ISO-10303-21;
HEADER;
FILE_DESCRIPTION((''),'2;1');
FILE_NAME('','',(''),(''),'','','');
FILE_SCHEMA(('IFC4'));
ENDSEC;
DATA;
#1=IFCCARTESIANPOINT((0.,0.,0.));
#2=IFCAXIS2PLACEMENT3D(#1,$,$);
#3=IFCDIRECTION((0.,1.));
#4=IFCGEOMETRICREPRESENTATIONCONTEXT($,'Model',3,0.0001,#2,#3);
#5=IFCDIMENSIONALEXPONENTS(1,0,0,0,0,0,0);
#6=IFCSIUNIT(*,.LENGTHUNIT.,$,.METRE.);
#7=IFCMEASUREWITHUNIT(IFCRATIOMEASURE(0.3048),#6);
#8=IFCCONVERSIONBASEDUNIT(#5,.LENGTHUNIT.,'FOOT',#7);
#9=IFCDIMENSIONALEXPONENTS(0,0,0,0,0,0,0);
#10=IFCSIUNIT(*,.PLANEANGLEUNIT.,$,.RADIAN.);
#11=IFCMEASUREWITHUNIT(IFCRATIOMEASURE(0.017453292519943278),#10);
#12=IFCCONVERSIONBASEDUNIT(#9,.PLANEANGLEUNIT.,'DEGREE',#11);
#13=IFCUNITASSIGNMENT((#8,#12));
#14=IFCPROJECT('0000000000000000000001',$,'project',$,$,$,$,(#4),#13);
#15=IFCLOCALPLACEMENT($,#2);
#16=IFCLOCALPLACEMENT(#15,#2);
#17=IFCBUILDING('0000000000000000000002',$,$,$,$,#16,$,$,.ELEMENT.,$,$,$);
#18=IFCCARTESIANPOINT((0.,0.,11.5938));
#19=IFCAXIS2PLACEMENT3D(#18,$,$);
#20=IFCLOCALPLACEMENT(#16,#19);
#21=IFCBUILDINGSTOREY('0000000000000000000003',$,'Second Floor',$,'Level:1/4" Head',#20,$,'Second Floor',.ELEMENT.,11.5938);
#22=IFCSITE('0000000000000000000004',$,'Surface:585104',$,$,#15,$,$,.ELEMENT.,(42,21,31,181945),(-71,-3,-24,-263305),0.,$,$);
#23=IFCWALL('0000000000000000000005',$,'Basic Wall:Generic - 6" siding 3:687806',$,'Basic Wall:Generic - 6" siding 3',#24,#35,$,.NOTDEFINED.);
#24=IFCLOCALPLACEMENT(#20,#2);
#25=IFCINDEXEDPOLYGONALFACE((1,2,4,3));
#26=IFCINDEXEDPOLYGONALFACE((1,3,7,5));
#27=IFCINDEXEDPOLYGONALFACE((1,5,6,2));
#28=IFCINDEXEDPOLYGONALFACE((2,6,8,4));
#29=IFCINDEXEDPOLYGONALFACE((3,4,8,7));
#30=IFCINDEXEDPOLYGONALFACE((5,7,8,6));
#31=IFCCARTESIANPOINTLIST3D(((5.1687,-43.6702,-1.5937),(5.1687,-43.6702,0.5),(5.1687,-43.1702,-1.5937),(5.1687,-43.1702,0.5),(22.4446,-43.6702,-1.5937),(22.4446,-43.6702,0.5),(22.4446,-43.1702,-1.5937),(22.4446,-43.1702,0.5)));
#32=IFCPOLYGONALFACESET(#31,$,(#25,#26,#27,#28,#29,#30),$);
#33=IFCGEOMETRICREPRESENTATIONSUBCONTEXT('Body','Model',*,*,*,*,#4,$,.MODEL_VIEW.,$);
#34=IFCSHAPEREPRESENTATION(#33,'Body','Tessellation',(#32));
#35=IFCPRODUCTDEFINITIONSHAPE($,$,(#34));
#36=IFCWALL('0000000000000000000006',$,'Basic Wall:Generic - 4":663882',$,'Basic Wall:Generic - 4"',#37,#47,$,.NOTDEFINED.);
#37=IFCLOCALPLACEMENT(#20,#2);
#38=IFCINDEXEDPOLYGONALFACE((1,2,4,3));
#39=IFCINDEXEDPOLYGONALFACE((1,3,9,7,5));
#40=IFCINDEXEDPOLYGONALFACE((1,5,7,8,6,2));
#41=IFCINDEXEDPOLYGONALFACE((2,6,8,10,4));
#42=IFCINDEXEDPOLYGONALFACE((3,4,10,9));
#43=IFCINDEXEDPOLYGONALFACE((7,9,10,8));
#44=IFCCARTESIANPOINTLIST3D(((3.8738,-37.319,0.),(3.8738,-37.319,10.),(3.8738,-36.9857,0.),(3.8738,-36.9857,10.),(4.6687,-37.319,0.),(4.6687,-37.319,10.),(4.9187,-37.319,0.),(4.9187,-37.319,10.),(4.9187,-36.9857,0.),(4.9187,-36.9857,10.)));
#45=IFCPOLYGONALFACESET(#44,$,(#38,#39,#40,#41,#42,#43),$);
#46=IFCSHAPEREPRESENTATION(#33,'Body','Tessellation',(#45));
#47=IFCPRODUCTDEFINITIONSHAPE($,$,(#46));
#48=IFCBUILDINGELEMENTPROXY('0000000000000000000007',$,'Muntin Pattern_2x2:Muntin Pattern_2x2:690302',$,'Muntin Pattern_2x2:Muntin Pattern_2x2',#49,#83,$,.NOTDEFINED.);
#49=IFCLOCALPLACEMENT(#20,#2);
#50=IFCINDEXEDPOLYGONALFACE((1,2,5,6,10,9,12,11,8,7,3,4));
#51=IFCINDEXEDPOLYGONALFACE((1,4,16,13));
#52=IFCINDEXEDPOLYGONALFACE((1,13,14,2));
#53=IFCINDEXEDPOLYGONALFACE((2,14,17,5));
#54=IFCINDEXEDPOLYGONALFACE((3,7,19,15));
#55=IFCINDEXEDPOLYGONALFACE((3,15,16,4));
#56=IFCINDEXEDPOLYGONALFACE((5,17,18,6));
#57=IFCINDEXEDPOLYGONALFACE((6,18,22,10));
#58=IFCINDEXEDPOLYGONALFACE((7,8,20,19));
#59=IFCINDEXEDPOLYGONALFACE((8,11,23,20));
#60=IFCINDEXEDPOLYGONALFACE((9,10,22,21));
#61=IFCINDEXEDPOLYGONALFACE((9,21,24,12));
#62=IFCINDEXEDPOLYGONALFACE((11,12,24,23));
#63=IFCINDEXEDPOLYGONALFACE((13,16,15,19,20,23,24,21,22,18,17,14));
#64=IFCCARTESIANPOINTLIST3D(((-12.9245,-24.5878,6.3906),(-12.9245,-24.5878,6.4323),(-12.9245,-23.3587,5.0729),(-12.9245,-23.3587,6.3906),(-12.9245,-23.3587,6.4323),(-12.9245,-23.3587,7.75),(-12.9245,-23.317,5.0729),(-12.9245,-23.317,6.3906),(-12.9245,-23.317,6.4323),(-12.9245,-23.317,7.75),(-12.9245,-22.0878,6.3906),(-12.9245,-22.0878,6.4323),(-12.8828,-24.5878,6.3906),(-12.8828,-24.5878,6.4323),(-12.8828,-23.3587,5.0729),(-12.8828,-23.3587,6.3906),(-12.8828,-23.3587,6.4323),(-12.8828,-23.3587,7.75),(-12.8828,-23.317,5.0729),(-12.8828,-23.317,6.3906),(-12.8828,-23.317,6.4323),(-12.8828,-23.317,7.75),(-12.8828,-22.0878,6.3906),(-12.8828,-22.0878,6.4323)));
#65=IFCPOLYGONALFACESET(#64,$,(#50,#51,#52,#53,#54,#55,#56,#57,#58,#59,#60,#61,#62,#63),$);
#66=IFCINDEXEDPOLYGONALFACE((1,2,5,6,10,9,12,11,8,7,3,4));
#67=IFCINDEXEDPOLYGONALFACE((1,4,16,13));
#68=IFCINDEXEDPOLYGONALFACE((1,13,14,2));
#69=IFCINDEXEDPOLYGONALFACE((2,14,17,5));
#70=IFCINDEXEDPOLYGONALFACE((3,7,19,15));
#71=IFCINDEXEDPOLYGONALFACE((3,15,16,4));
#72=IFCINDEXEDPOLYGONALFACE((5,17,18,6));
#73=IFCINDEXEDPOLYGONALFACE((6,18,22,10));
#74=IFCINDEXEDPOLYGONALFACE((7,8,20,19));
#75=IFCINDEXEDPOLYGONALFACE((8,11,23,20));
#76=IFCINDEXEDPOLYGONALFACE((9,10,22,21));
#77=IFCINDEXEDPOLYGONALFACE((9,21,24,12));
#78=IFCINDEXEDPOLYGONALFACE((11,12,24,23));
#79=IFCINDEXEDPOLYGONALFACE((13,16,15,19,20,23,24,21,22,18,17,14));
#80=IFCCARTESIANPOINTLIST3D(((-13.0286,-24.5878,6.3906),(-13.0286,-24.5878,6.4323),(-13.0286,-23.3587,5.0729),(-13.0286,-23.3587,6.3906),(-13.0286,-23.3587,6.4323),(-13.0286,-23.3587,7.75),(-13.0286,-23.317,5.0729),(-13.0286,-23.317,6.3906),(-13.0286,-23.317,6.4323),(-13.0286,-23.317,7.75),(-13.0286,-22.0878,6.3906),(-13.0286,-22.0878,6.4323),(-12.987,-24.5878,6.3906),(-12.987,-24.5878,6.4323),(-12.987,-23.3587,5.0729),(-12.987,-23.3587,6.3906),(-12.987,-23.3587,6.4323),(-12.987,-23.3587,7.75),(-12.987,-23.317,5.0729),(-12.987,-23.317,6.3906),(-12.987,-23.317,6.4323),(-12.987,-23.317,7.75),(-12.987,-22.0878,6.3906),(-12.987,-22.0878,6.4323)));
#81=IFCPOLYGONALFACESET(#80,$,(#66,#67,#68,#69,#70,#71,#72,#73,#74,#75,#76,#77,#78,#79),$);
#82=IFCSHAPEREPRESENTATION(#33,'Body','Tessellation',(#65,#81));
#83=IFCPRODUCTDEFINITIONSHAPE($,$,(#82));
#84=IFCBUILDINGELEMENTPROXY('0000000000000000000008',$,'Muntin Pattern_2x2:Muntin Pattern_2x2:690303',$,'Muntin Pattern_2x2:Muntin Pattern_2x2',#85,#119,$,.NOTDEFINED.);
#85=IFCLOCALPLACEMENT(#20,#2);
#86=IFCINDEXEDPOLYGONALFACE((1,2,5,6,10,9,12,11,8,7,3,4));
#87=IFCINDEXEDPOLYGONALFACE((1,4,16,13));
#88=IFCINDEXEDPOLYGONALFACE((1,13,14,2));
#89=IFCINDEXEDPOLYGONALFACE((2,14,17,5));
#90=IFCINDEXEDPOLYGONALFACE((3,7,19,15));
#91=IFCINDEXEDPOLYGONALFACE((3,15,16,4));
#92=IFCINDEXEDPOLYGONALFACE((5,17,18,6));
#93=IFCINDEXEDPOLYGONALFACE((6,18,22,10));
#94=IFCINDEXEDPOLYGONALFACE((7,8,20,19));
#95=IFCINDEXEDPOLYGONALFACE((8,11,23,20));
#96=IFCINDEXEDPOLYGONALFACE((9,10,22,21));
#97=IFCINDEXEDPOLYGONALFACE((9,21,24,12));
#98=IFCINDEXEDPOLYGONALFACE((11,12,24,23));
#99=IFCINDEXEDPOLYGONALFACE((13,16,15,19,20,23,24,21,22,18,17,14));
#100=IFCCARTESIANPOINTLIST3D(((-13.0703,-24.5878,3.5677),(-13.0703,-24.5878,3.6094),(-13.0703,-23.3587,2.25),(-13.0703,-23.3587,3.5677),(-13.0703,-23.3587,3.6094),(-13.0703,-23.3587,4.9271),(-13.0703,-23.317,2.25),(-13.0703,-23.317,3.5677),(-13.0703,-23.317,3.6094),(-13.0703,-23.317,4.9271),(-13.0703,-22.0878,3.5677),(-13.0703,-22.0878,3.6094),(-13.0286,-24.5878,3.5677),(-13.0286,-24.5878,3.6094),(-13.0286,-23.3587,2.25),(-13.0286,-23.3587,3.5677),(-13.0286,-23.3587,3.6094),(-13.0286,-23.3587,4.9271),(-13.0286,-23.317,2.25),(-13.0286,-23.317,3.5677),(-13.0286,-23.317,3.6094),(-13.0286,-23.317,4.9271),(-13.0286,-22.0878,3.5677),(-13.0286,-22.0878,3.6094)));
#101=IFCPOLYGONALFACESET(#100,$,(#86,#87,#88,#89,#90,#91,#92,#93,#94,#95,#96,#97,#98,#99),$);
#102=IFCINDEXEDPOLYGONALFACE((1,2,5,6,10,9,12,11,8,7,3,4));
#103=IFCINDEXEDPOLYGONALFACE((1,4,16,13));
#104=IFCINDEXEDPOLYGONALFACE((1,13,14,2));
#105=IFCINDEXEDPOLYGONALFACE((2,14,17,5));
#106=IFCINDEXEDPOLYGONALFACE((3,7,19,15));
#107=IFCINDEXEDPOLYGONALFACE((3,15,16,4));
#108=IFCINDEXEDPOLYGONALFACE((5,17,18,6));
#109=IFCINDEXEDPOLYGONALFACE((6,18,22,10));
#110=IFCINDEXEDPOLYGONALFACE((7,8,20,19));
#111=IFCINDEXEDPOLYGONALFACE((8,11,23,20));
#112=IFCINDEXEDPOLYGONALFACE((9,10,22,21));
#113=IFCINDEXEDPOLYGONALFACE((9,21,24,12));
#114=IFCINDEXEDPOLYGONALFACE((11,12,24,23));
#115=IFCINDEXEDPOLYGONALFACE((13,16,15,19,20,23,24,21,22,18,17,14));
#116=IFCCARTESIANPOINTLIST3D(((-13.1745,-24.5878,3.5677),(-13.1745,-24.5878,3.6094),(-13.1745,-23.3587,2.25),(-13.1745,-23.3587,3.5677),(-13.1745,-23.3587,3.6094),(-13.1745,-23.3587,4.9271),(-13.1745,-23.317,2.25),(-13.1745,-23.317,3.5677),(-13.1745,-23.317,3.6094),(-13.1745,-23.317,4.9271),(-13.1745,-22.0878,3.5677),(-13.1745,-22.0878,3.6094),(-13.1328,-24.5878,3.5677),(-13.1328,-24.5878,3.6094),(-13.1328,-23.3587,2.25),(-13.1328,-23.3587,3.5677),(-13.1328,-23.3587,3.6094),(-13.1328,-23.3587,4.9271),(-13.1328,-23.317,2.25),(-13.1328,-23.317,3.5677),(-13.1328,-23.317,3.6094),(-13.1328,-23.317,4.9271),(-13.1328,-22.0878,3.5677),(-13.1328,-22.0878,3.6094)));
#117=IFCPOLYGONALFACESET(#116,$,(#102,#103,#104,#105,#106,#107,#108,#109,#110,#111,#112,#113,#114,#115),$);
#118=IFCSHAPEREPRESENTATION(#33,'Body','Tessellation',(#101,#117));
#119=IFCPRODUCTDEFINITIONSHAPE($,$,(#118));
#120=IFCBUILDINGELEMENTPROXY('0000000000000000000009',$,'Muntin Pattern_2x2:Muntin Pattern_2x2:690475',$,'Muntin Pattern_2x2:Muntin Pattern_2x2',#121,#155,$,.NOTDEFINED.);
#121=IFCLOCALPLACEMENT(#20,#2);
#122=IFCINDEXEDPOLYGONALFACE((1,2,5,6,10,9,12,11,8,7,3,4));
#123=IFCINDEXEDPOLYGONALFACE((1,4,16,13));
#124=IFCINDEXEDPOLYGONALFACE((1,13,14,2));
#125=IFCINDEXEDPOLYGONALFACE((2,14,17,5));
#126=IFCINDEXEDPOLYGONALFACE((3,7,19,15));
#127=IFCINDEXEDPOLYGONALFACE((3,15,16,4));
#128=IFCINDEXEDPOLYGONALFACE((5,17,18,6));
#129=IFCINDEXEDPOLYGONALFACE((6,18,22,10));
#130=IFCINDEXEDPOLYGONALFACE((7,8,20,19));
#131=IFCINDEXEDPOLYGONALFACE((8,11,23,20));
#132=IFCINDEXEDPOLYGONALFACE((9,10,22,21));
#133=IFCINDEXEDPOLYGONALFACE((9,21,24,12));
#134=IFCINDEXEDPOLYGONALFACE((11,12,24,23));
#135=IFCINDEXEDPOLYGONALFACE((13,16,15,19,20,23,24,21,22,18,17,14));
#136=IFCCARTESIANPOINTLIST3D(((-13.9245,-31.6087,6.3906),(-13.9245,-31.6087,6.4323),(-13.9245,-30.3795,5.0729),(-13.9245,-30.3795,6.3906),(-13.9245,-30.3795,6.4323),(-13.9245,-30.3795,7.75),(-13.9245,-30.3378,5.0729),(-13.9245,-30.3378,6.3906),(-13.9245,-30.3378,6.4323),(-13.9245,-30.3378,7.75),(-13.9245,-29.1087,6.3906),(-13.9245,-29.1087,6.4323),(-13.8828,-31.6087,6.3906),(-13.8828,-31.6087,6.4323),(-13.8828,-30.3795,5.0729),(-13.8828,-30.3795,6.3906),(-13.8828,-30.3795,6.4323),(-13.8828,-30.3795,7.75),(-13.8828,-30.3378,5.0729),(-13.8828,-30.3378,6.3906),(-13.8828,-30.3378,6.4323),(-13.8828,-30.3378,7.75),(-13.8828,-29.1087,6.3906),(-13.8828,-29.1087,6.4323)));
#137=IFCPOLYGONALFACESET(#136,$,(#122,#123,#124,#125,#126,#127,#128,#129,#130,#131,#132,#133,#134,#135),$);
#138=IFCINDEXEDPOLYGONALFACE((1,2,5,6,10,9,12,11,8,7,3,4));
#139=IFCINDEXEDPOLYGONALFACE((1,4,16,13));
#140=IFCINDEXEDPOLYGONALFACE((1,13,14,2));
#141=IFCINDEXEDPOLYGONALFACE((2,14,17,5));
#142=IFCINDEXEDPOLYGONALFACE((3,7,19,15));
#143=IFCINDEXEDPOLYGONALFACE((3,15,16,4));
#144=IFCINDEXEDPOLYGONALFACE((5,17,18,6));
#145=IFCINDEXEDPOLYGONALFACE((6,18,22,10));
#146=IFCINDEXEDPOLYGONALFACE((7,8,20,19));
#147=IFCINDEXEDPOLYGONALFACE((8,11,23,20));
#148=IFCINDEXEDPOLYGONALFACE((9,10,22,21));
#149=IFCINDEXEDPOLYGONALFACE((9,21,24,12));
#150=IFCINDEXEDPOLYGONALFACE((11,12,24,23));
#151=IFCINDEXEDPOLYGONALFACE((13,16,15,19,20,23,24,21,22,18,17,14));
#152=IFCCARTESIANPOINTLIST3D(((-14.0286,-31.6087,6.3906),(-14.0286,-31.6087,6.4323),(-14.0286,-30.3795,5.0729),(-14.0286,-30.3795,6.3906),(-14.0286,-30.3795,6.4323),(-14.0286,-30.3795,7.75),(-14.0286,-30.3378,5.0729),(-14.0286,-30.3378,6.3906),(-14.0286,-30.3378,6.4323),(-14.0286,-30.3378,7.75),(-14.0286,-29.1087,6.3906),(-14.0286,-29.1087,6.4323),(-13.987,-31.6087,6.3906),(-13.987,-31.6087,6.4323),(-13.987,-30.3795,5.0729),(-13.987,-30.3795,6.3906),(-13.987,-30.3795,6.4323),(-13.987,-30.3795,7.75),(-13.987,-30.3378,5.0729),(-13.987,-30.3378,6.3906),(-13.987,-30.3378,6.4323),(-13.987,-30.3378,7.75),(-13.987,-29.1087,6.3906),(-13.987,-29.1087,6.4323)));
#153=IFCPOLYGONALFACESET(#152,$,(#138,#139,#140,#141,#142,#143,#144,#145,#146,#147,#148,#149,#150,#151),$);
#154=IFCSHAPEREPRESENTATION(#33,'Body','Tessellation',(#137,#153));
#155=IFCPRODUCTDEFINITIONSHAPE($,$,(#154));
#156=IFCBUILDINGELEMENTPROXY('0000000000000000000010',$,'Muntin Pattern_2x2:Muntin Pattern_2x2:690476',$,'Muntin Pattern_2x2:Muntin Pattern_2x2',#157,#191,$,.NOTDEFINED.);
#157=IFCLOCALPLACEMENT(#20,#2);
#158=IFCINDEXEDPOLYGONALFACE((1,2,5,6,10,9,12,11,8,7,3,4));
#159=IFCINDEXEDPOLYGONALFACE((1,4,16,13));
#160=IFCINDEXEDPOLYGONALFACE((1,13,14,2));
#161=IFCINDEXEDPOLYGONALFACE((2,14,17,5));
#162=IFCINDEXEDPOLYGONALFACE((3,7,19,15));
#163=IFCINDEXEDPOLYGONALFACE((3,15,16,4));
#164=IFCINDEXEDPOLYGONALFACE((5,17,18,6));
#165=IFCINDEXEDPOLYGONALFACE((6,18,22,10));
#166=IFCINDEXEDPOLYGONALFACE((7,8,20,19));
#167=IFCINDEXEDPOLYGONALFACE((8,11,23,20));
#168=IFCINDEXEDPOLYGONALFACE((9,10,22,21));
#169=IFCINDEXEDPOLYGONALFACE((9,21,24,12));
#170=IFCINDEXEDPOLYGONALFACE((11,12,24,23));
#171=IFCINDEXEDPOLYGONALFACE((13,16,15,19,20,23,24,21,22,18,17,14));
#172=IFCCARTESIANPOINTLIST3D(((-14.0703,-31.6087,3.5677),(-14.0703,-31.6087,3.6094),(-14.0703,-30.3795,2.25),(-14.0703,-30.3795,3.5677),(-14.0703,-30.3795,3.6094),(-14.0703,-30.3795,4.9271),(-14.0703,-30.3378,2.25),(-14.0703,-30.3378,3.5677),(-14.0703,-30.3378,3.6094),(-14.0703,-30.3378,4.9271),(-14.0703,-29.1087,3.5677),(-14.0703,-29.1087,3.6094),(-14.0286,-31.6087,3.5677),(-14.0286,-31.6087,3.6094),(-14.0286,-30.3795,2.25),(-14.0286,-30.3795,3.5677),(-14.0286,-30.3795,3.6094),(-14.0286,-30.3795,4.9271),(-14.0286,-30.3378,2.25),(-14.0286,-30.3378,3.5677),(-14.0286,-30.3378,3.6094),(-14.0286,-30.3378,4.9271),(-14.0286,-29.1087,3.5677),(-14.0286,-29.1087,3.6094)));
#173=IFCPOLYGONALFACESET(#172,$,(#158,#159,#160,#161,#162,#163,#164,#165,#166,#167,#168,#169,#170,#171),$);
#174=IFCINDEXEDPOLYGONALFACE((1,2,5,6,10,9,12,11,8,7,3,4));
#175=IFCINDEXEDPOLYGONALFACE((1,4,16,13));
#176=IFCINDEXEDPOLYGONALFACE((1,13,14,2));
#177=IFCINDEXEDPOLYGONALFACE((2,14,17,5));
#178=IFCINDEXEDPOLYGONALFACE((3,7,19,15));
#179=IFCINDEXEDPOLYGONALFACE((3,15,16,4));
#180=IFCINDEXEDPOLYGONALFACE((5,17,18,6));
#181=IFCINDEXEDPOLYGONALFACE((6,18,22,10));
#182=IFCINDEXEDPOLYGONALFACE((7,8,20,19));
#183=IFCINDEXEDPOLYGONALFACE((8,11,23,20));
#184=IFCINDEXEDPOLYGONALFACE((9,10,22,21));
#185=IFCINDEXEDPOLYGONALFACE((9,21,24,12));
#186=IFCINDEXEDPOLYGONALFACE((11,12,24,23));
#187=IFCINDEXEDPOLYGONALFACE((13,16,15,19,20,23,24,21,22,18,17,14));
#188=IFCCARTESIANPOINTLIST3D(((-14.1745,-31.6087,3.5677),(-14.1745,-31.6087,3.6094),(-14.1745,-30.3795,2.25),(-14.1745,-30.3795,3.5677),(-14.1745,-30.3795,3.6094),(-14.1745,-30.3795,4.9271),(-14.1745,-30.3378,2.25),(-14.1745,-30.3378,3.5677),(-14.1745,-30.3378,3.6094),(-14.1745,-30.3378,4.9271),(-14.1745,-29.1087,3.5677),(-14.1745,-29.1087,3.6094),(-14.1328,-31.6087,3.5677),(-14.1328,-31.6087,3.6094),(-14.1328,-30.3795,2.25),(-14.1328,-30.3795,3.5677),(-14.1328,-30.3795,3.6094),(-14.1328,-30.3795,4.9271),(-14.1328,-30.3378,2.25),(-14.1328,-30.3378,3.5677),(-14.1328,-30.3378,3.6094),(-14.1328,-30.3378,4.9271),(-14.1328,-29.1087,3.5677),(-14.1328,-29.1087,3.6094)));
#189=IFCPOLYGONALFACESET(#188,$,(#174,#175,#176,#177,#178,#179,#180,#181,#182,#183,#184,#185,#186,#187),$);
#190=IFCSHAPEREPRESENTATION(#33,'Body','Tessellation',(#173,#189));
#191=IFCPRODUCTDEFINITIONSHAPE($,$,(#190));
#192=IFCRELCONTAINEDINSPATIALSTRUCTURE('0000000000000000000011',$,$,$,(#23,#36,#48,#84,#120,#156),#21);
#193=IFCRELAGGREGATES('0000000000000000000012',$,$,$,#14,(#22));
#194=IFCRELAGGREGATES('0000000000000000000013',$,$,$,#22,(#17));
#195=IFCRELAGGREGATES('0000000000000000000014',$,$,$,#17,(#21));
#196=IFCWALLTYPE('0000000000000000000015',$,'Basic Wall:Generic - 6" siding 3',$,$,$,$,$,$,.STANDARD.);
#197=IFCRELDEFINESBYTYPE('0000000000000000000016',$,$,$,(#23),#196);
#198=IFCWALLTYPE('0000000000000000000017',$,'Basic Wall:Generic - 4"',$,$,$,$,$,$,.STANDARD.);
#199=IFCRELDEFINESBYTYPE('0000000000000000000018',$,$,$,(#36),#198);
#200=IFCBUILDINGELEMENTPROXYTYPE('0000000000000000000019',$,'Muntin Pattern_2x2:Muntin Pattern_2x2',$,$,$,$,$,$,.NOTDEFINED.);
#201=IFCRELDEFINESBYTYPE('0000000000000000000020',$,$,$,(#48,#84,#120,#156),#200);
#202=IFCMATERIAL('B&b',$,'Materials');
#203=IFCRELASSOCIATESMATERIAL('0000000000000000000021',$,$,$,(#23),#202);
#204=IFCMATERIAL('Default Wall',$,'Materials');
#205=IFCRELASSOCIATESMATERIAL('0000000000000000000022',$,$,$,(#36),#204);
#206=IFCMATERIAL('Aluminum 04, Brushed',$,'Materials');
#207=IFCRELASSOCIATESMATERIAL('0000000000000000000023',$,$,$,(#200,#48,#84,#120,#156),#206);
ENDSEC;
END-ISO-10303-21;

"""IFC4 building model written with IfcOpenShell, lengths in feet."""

from ifc_helpers import new_model, entity, si_unit, converted_unit, direction, frame, origin, place, context, subcontext, project, spatial, indexed_curve, outline, extrude, source, transform, mapped, material, type_object, type_shapes, element, save


model = new_model("IFC4")

# Units and contexts
model_context = context("Model", 3, precision=0.0001, world=origin(), true_north=direction((0.0, 1.0)))
body_context = subcontext(model_context, "Body", "Model", "MODEL_VIEW")
ifc_project = project(units=[converted_unit("LENGTHUNIT", "FOOT", entity("IfcRatioMeasure", 0.3048), si_unit("LENGTHUNIT", "METRE"), dimensions=[1, 0, 0, 0, 0, 0, 0]), converted_unit("PLANEANGLEUNIT", "DEGREE", entity("IfcRatioMeasure", 0.017453292519943278), si_unit("PLANEANGLEUNIT", "RADIAN"), dimensions=[0, 0, 0, 0, 0, 0, 0])], contexts=[model_context])

# Site, building, storey
site_placement = place(None, origin())
site = spatial("IfcSite", under=ifc_project, at=site_placement, Name="Surface:585104", CompositionType="ELEMENT", RefLatitude=(42, 21, 31, 181945), RefLongitude=(-71, -3, -24, -263305), RefElevation=0.0)
building_placement = place(site_placement, origin())
building = spatial("IfcBuilding", under=site, at=building_placement, CompositionType="ELEMENT")
storey_placement = place(building_placement, frame((0.0, 0.0, 11.5938)))
storey = spatial("IfcBuildingStorey", under=building, at=storey_placement, Name="Second Floor", ObjectType="Level:1/4\" Head", LongName="Second Floor", CompositionType="ELEMENT", Elevation=11.5938)

# Walls
ifc_material_1 = material(Name="B&b", Category="Materials")
wall_type_1 = type_object("IfcWallType", Name="Basic Wall:Generic - 6\" siding 3", PredefinedType="STANDARD")
wall_1_placement = place(storey_placement, frame((5.1687, -43.4202, -1.5938)))
element("IfcWall", 1, at=wall_1_placement, inside=storey, type_object=wall_type_1, material=ifc_material_1, Name="Basic Wall:Generic - 6\" siding 3:687806", ObjectType="Basic Wall:Generic - 6\" siding 3", PredefinedType="NOTDEFINED", context=body_context, shape_type="SweptSolid", body=[
    extrude(outline(indexed_curve([(17.2759, -0.25), (17.2759, 0.25), (0.0, 0.25), (0.0, -0.25), (17.2759, -0.25)], self_intersect=False)), origin(), (0.0, 0.0, 1.0), 2.0938),
])
ifc_material_2 = material(Name="Default Wall", Category="Materials")
wall_type_2 = type_object("IfcWallType", Name="Basic Wall:Generic - 4\"", PredefinedType="STANDARD")
wall_2_placement = place(storey_placement, frame((4.9187, -37.1524, 0.0), z_axis=(0.0, 0.0, 1.0), x_axis=(-1.0, 0.0, 0.0)))
element("IfcWall", 2, at=wall_2_placement, inside=storey, type_object=wall_type_2, material=ifc_material_2, Name="Basic Wall:Generic - 4\":663882", ObjectType="Basic Wall:Generic - 4\"", PredefinedType="NOTDEFINED", context=body_context, shape_type="SweptSolid", body=[
    extrude(outline(indexed_curve([(1.0449, -0.1667), (1.0449, 0.1667), (0.25, 0.1667), (0.0, 0.1667), (0.0, -0.1667), (1.0449, -0.1667)], self_intersect=False)), origin(), (0.0, 0.0, 1.0), 10.0),
])

# Building element proxies
ifc_material_3 = material(Name="Aluminum 04, Brushed", Category="Materials")
building_element_proxy_type_1 = type_object("IfcBuildingElementProxyType", Name="Muntin Pattern_2x2:Muntin Pattern_2x2", PredefinedType="NOTDEFINED", material=ifc_material_3)
shared_shape_1 = source(origin(), body_context, "Body", "SweptSolid", [
    extrude(outline(indexed_curve([(0.0208, -0.0208), (1.3385, -0.0208), (1.3385, 0.0208), (0.0208, 0.0208), (0.0208, 1.25), (-0.0208, 1.25), (-0.0208, 0.0208), (-1.3385, 0.0208), (-1.3385, -0.0208), (-0.0208, -0.0208), (-0.0208, -1.25), (0.0208, -1.25), (0.0208, -0.0208)], self_intersect=False)), frame((0.0, -0.0729, 1.3385), z_axis=(0.0, 1.0, 0.0), x_axis=(0.0, 0.0, 1.0)), (0.0, 0.0, 1.0), 0.0417),
    extrude(outline(indexed_curve([(0.0208, -0.0208), (1.3385, -0.0208), (1.3385, 0.0208), (0.0208, 0.0208), (0.0208, 1.25), (-0.0208, 1.25), (-0.0208, 0.0208), (-1.3385, 0.0208), (-1.3385, -0.0208), (-0.0208, -0.0208), (-0.0208, -1.25), (0.0208, -1.25), (0.0208, -0.0208)], self_intersect=False)), frame((0.0, 0.0313, 1.3385), z_axis=(0.0, 1.0, 0.0), x_axis=(0.0, 0.0, 1.0)), (0.0, 0.0, 1.0), 0.0417),
])
type_shapes(building_element_proxy_type_1, [shared_shape_1])
for number, where, z_axis, x_axis, name in (
    (3, (-12.9557, -23.3378, 5.0729), (0.0, 0.0, 1.0), (0.0, 1.0, 0.0), "Muntin Pattern_2x2:Muntin Pattern_2x2:690302"),
    (4, (-13.1015, -23.3378, 2.25), (0.0, 0.0, 1.0), (0.0, 1.0, 0.0), "Muntin Pattern_2x2:Muntin Pattern_2x2:690303"),
    (5, (-13.9557, -30.3587, 5.0729), (0.0, 0.0, 1.0), (0.0, 1.0, 0.0), "Muntin Pattern_2x2:Muntin Pattern_2x2:690475"),
    (6, (-14.1015, -30.3587, 2.25), (0.0, 0.0, 1.0), (0.0, 1.0, 0.0), "Muntin Pattern_2x2:Muntin Pattern_2x2:690476"),
):
    element("IfcBuildingElementProxy", number, at=place(storey_placement, frame(where, z_axis=z_axis, x_axis=x_axis)), inside=storey, type_object=building_element_proxy_type_1, material=ifc_material_3, Name=name, ObjectType="Muntin Pattern_2x2:Muntin Pattern_2x2", PredefinedType="NOTDEFINED", context=body_context, shape_type="MappedRepresentation", body=[
        mapped(shared_shape_1, transform((0.0, 0.0, 0.0), scale=1.0)),
    ])

save(model, "model.ifc")
